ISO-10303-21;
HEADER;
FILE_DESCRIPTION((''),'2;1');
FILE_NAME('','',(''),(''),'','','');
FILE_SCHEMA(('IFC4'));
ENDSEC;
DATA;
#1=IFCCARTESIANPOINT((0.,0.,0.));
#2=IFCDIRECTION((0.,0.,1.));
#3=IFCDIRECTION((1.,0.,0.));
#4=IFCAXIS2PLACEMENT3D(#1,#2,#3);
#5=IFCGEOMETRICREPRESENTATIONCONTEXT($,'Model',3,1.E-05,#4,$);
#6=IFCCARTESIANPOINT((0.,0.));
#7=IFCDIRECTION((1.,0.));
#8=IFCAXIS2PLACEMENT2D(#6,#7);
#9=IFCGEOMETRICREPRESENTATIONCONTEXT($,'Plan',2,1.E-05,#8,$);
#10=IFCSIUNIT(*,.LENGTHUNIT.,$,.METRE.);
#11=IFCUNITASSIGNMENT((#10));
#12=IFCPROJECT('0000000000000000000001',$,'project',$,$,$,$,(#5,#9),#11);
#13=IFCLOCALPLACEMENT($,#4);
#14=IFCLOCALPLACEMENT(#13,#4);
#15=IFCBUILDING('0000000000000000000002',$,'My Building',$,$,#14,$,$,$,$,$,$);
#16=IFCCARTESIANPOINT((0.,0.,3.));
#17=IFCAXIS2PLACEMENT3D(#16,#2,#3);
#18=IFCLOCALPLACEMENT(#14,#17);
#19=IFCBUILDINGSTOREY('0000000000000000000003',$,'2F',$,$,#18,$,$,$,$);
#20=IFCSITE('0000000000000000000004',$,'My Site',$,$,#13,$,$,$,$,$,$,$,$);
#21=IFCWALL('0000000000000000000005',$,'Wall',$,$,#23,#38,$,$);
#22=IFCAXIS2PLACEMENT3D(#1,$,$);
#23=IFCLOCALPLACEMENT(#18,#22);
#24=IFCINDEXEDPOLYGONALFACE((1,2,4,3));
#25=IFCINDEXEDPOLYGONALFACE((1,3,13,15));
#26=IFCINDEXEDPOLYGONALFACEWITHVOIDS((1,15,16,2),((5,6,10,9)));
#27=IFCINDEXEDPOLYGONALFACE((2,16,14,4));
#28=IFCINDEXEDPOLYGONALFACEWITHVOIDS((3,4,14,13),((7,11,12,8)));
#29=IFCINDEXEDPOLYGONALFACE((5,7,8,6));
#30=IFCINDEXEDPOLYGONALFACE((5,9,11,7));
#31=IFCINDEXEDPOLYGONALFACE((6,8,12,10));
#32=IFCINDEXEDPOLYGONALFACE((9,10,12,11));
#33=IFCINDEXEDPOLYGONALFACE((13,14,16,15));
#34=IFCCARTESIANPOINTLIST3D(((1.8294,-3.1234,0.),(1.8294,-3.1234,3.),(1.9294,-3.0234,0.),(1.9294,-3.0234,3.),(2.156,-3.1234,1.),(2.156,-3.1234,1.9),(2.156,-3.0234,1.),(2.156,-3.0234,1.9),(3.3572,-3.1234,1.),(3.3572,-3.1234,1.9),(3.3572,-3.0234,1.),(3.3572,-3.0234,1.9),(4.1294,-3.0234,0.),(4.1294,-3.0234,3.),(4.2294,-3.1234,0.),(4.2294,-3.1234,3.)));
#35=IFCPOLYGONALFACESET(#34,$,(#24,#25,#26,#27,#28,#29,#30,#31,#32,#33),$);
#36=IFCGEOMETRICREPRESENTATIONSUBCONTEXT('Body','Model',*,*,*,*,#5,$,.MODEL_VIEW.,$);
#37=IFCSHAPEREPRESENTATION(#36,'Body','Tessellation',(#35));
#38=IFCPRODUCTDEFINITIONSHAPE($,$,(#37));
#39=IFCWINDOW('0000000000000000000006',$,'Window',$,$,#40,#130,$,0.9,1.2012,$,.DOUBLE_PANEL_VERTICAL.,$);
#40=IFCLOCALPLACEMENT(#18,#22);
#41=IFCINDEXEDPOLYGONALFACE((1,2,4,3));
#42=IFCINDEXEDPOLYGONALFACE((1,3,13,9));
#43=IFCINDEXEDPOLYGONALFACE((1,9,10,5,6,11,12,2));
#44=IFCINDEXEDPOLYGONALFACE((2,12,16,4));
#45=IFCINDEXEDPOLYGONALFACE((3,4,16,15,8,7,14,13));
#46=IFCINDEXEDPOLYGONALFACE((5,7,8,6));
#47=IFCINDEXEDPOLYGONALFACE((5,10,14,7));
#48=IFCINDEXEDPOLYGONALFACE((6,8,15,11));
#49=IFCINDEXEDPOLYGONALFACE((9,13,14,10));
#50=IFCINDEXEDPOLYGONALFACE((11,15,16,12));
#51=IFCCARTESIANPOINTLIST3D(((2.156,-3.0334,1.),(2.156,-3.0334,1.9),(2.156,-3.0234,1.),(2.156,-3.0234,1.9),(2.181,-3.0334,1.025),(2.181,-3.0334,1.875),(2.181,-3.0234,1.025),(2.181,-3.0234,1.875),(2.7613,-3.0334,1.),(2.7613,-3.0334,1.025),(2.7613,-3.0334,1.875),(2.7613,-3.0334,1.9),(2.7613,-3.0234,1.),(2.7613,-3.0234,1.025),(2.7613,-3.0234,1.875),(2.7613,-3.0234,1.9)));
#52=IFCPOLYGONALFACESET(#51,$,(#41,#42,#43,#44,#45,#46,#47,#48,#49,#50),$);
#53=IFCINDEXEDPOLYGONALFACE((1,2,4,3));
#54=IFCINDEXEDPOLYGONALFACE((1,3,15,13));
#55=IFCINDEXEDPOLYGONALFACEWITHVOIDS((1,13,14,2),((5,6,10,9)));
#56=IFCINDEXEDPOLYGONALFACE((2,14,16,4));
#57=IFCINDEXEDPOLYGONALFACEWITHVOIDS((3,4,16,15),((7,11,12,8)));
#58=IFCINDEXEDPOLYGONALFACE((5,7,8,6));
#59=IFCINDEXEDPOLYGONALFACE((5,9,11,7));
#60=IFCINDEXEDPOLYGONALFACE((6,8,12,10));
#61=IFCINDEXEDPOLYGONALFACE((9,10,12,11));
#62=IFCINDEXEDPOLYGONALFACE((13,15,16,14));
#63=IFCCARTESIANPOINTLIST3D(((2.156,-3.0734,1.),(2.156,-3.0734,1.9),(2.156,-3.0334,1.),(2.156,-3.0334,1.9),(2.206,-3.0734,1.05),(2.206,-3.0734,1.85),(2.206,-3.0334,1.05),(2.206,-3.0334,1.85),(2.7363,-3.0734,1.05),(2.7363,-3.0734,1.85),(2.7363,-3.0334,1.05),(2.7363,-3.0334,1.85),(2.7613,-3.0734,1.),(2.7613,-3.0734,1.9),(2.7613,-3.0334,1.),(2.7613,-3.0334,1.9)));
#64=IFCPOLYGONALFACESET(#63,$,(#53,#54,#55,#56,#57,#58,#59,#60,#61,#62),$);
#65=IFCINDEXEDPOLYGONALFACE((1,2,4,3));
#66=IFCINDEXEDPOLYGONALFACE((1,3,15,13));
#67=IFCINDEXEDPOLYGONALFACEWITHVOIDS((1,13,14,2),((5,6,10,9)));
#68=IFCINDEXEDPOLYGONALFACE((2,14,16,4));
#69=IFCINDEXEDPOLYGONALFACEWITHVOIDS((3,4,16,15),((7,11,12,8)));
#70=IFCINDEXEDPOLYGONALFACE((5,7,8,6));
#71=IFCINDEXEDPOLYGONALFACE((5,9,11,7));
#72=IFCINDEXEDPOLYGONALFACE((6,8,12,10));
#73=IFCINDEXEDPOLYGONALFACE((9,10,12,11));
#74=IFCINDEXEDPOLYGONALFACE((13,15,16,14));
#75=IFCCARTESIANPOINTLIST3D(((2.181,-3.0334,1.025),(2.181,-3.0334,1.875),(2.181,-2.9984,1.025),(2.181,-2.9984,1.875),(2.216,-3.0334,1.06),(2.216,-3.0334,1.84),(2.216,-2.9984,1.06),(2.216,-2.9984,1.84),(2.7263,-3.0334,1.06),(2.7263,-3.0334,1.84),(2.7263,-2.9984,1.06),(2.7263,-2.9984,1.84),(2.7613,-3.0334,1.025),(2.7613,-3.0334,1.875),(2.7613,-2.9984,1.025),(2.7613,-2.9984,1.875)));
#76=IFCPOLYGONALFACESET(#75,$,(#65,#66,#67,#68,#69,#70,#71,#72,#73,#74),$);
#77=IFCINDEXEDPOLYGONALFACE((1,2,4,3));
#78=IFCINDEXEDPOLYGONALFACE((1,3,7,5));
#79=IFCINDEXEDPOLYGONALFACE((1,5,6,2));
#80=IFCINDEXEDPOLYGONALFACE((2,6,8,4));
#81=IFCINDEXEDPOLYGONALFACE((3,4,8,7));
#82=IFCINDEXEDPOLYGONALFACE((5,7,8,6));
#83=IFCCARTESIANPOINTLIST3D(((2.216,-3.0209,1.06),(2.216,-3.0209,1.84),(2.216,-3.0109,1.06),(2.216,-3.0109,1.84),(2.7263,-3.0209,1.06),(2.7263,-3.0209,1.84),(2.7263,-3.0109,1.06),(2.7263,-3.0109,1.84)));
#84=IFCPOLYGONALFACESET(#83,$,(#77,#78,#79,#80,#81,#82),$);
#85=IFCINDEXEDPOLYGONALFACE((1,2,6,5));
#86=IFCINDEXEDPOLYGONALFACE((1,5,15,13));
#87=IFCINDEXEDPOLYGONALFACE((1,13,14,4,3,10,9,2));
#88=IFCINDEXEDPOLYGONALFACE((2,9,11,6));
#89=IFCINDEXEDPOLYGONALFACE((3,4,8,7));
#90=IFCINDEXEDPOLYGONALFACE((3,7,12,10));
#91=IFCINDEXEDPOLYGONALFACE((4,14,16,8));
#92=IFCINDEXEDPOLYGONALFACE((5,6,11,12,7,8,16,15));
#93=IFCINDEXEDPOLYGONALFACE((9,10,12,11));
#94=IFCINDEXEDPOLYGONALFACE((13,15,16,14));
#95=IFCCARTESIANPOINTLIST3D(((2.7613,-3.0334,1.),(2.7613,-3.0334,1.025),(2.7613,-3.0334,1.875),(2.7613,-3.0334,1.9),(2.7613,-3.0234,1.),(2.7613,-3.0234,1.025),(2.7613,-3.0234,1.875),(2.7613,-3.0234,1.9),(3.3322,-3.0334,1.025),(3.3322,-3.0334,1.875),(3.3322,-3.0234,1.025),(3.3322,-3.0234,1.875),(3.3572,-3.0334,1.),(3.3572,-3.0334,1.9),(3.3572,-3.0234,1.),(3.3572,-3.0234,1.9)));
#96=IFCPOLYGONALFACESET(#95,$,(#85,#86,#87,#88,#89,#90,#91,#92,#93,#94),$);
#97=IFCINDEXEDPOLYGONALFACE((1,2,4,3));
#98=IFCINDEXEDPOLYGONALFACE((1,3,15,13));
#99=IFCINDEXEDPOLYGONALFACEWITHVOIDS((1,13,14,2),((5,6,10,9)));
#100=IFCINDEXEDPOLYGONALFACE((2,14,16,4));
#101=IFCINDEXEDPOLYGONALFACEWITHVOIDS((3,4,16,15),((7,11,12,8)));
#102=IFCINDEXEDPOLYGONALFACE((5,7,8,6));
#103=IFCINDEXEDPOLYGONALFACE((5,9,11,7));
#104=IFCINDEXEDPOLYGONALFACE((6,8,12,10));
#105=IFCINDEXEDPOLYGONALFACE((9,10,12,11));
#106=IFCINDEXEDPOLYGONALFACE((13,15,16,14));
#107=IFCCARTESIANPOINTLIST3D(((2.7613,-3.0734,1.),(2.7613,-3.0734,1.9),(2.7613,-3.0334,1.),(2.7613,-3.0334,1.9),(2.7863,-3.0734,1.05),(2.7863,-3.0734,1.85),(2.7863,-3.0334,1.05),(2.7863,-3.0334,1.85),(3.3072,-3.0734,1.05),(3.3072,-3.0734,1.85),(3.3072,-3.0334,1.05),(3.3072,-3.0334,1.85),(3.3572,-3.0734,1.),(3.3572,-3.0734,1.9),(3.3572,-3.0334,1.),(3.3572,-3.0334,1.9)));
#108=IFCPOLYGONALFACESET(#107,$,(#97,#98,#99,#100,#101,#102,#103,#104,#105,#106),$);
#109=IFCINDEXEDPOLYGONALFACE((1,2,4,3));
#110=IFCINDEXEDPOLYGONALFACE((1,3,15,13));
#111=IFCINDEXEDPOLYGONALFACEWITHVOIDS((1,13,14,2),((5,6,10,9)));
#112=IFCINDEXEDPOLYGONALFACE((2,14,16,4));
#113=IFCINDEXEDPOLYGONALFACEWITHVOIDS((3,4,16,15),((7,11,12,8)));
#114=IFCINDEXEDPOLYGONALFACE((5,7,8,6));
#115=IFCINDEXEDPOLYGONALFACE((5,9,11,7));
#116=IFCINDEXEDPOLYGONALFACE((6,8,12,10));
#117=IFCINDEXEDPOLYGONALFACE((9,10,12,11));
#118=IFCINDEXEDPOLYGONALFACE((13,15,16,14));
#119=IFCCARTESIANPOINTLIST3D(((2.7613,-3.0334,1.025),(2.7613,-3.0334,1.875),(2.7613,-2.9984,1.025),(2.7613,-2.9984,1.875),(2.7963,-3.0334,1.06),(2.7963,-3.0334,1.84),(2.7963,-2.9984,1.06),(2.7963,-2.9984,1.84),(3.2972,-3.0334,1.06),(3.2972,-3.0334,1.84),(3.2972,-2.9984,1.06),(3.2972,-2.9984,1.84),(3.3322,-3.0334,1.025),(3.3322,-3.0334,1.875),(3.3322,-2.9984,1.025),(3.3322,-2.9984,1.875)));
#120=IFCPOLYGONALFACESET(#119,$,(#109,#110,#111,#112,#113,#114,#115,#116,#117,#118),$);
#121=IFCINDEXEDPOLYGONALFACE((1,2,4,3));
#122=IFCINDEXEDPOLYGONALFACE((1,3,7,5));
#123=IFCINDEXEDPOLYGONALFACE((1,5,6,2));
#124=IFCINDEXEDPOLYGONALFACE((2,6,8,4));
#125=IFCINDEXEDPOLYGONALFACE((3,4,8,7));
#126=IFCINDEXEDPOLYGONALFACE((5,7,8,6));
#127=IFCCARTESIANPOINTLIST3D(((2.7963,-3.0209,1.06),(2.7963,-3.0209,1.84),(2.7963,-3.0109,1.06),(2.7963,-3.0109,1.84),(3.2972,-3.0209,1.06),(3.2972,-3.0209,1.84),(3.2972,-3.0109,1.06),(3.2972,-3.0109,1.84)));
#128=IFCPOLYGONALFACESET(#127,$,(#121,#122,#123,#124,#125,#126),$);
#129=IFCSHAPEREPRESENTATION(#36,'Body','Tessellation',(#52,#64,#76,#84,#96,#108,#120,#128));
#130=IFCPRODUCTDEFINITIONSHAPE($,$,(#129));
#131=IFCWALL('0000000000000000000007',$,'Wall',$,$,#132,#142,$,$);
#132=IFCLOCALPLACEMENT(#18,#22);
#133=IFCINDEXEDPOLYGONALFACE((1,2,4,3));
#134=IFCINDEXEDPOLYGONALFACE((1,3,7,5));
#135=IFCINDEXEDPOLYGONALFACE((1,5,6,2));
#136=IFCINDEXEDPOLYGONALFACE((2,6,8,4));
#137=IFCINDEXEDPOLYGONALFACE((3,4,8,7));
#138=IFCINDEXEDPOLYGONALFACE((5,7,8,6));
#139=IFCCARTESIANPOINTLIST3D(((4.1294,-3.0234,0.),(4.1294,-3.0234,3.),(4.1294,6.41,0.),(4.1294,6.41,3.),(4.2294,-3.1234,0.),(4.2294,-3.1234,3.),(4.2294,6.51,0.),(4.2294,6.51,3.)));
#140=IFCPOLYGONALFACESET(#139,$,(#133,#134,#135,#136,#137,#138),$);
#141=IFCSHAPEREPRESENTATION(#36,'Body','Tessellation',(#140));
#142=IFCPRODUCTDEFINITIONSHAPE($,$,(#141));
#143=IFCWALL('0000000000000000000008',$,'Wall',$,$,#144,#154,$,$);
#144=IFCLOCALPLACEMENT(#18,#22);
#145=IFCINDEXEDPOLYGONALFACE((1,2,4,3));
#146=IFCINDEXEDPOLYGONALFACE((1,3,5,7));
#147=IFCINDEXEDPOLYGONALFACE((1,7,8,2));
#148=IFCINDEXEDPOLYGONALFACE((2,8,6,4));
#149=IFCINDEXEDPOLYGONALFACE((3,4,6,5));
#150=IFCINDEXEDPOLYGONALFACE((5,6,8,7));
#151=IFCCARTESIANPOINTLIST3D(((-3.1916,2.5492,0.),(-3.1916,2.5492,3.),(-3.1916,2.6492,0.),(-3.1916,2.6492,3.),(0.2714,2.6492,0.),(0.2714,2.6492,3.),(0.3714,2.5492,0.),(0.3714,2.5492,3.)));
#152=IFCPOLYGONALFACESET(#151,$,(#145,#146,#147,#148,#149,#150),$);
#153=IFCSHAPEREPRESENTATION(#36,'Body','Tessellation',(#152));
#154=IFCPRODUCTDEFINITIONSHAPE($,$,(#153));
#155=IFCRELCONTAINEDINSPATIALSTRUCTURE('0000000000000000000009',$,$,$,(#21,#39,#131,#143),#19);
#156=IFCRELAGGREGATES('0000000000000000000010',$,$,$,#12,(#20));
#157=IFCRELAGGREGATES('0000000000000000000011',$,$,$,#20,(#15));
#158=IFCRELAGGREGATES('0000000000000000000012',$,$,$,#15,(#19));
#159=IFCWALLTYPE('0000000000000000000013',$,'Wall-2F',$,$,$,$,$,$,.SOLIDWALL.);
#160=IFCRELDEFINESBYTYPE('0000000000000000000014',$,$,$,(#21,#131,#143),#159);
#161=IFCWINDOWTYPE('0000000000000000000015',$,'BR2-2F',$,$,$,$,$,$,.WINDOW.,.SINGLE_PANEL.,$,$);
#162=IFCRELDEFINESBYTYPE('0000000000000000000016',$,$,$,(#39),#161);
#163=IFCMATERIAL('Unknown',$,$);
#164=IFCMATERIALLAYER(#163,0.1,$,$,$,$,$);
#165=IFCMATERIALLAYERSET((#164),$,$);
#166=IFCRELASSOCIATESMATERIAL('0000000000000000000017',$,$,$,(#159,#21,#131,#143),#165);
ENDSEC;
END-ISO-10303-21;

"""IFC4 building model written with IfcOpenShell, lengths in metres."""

from ifc_helpers import new_model, entity, si_unit, frame, origin_with_axes, origin_2d_with_axis, place, context, subcontext, project, spatial, line, indexed_curve, outline, extrude, shape, source, transform, mapped, material, layer, layer_set, layer_usage, type_object, type_shapes, element, fill, save


model = new_model("IFC4")

# Units and contexts
model_context = context("Model", 3, precision=1e-05, world=origin_with_axes())
plan_context = context("Plan", 2, precision=1e-05, world=origin_2d_with_axis())
body_context_1 = subcontext(model_context, "Body", "Model", "MODEL_VIEW")
body_context_2 = subcontext(plan_context, "Body", "Plan", "PLAN_VIEW")
ifc_project = project(units=[si_unit("LENGTHUNIT", "METRE")], contexts=[model_context, plan_context])

# Site, building, storey
site_placement = place(None, origin_with_axes())
site = spatial("IfcSite", under=ifc_project, at=site_placement, Name="My Site")
building_placement = place(site_placement, origin_with_axes())
building = spatial("IfcBuilding", under=site, at=building_placement, Name="My Building")
storey_placement = place(building_placement, frame((0.0, 0.0, 3.0), z_axis=(0.0, 0.0, 1.0), x_axis=(1.0, 0.0, 0.0)))
storey = spatial("IfcBuildingStorey", under=building, at=storey_placement, Name="2F")

# Shared definitions
ifc_material = material(Name="Unknown")

# Shared definitions
ifc_layer_1 = layer(ifc_material, 0.1)
ifc_layer_set_1 = layer_set([ifc_layer_1])
wall_type_1 = type_object("IfcWallType", Name="Wall-2F", PredefinedType="SOLIDWALL", material=ifc_layer_set_1)

# Wall, opening, window
ifc_layer_usage_1 = layer_usage(ifc_layer_set_1, "AXIS2", "POSITIVE", 0.0)
wall_1_placement = place(storey_placement, frame((1.8294, -3.1234, 0.0), z_axis=(0.0, 0.0, 1.0), x_axis=(1.0, 0.0, 0.0)))
wall_1 = element("IfcWall", 1, at=wall_1_placement, inside=storey, type_object=wall_type_1, material=ifc_layer_usage_1, Name="Wall", context=body_context_1, shape_type="SweptSolid", body=[
    extrude(outline(indexed_curve([(0.0, 0.0), (0.1, 0.1), (2.3, 0.1), (2.4, 0.0)], segments=[line(1, 2, 3, 4, 1)])), origin_with_axes(), (0.0, 0.0, 1.0), 3.0),
])
shared_shape_1 = source(origin_with_axes(), body_context_1, "Body", "SweptSolid", [
    extrude(outline(indexed_curve([(0.0, 0.0), (1.2012, 0.0), (1.2012, 0.9), (0.0, 0.9)], segments=[line(1, 2, 3, 4, 1)])), frame((0.0, -0.6, 0.0), z_axis=(0.0, -1.0, 0.0), x_axis=(1.0, 0.0, 0.0)), (0.0, 0.0, -1.0), 1.2),
])
opening_1_placement = place(wall_1_placement, frame((0.3266, 0.0, 1.0), z_axis=(0.0, 0.0, 1.0), x_axis=(1.0, 0.0, 0.0)))
opening_1 = element("IfcOpeningElement", 2, at=opening_1_placement, cuts=wall_1, PredefinedType="OPENING", context=body_context_1, shape_type="MappedRepresentation", body=[
    mapped(shared_shape_1, transform((0.0, 0.0, 0.0), x_axis=(1.0, 0.0, 0.0), y_axis=(0.0, 1.0, 0.0), z_axis=(0.0, 0.0, 1.0), scale=1.0)),
])
window_type = type_object("IfcWindowType", Name="BR2-2F", PartitioningType="SINGLE_PANEL", PredefinedType="WINDOW")
shared_shape_2 = source(origin_with_axes(), body_context_1, "Body", "SweptSolid", [
    extrude(outline(indexed_curve([(0.6053, 0.0), (0.0, 0.0), (0.0, 0.9), (0.6053, 0.9), (0.6053, 0.875), (0.025, 0.875), (0.025, 0.025), (0.6053, 0.025)], segments=[line(1, 2, 3, 4, 5, 6, 7, 8, 1)])), frame((0.0, 0.09, 0.0), z_axis=(0.0, -1.0, 0.0), x_axis=(1.0, 0.0, 0.0)), (0.0, 0.0, -1.0), 0.01),
    extrude(outline(indexed_curve([(0.0, 0.0), (0.6053, 0.0), (0.6053, 0.9), (0.0, 0.9)], segments=[line(1, 2, 3, 4, 1)]), holes=[indexed_curve([(0.05, 0.05), (0.5803, 0.05), (0.5803, 0.85), (0.05, 0.85)], segments=[line(1, 2, 3, 4, 1)])]), frame((0.0, 0.05, 0.0), z_axis=(0.0, -1.0, 0.0), x_axis=(1.0, 0.0, 0.0)), (0.0, 0.0, -1.0), 0.04),
    extrude(outline(indexed_curve([(0.0, 0.0), (0.5803, 0.0), (0.5803, 0.85), (0.0, 0.85)], segments=[line(1, 2, 3, 4, 1)]), holes=[indexed_curve([(0.035, 0.035), (0.5453, 0.035), (0.5453, 0.815), (0.035, 0.815)], segments=[line(1, 2, 3, 4, 1)])]), frame((0.025, 0.09, 0.025), z_axis=(0.0, -1.0, 0.0), x_axis=(1.0, 0.0, 0.0)), (0.0, 0.0, -1.0), 0.035),
    extrude(outline(indexed_curve([(0.035, 0.035), (0.5453, 0.035), (0.5453, 0.815), (0.035, 0.815)], segments=[line(1, 2, 3, 4, 1)])), frame((0.025, 0.1025, 0.025), z_axis=(0.0, -1.0, 0.0), x_axis=(1.0, 0.0, 0.0)), (0.0, 0.0, -1.0), 0.01),
    extrude(outline(indexed_curve([(0.0, 0.9), (0.5958, 0.9), (0.5958, 0.0), (0.0, 0.0), (0.0, 0.025), (0.5708, 0.025), (0.5708, 0.875), (0.0, 0.875)], segments=[line(1, 2, 3, 4, 5, 6, 7, 8, 1)])), frame((0.6053, 0.09, 0.0), z_axis=(0.0, -1.0, 0.0), x_axis=(1.0, 0.0, 0.0)), (0.0, 0.0, -1.0), 0.01),
    extrude(outline(indexed_curve([(0.0, 0.0), (0.5958, 0.0), (0.5958, 0.9), (0.0, 0.9)], segments=[line(1, 2, 3, 4, 1)]), holes=[indexed_curve([(0.025, 0.05), (0.5458, 0.05), (0.5458, 0.85), (0.025, 0.85)], segments=[line(1, 2, 3, 4, 1)])]), frame((0.6053, 0.05, 0.0), z_axis=(0.0, -1.0, 0.0), x_axis=(1.0, 0.0, 0.0)), (0.0, 0.0, -1.0), 0.04),
    extrude(outline(indexed_curve([(0.0, 0.0), (0.5708, 0.0), (0.5708, 0.85), (0.0, 0.85)], segments=[line(1, 2, 3, 4, 1)]), holes=[indexed_curve([(0.035, 0.035), (0.5358, 0.035), (0.5358, 0.815), (0.035, 0.815)], segments=[line(1, 2, 3, 4, 1)])]), frame((0.6053, 0.09, 0.025), z_axis=(0.0, -1.0, 0.0), x_axis=(1.0, 0.0, 0.0)), (0.0, 0.0, -1.0), 0.035),
    extrude(outline(indexed_curve([(0.035, 0.035), (0.5358, 0.035), (0.5358, 0.815), (0.035, 0.815)], segments=[line(1, 2, 3, 4, 1)])), frame((0.6053, 0.1025, 0.025), z_axis=(0.0, -1.0, 0.0), x_axis=(1.0, 0.0, 0.0)), (0.0, 0.0, -1.0), 0.01),
])
shared_shape_3 = source(origin_with_axes(), body_context_2, "Body", "Curve2D", [
    entity("IfcIndexedPolyCurve", entity("IfcCartesianPointList2D", [[0.05, 0.05], [0.5803, 0.05]])),
    entity("IfcIndexedPolyCurve", entity("IfcCartesianPointList2D", [[0.0, 0.1], [0.025, 0.1], [0.025, 0.09], [0.05, 0.09], [0.05, 0.05], [0.0, 0.05]]), [entity("IfcLineIndex", [1, 2, 3, 4, 5, 6, 1])]),
    entity("IfcIndexedPolyCurve", entity("IfcCartesianPointList2D", [[0.6053, 0.1], [0.6053, 0.1], [0.6053, 0.09], [0.5803, 0.09], [0.5803, 0.05], [0.6053, 0.05]])),
    entity("IfcIndexedPolyCurve", entity("IfcCartesianPointList2D", [[0.025, 0.09], [0.06, 0.09], [0.06, 0.125], [0.025, 0.125]]), [entity("IfcLineIndex", [1, 2, 3, 4, 1])]),
    entity("IfcIndexedPolyCurve", entity("IfcCartesianPointList2D", [[0.6053, 0.09], [0.5703, 0.09], [0.5703, 0.125], [0.6053, 0.125]]), [entity("IfcLineIndex", [1, 2, 3, 4, 1])]),
    entity("IfcIndexedPolyCurve", entity("IfcCartesianPointList2D", [[0.06, 0.09], [0.5703, 0.09]])),
    entity("IfcIndexedPolyCurve", entity("IfcCartesianPointList2D", [[0.06, 0.125], [0.5703, 0.125]])),
    entity("IfcIndexedPolyCurve", entity("IfcCartesianPointList2D", [[0.06, 0.1075], [0.5703, 0.1075]])),
    entity("IfcIndexedPolyCurve", entity("IfcCartesianPointList2D", [[0.6303, 0.05], [1.1512, 0.05]])),
    entity("IfcIndexedPolyCurve", entity("IfcCartesianPointList2D", [[0.6053, 0.1], [0.6053, 0.1], [0.6053, 0.09], [0.6303, 0.09], [0.6303, 0.05], [0.6053, 0.05]])),
    entity("IfcIndexedPolyCurve", entity("IfcCartesianPointList2D", [[1.2012, 0.1], [1.1762, 0.1], [1.1762, 0.09], [1.1512, 0.09], [1.1512, 0.05], [1.2012, 0.05]]), [entity("IfcLineIndex", [1, 2, 3, 4, 5, 6, 1])]),
    entity("IfcIndexedPolyCurve", entity("IfcCartesianPointList2D", [[0.6053, 0.09], [0.6403, 0.09], [0.6403, 0.125], [0.6053, 0.125]]), [entity("IfcLineIndex", [1, 2, 3, 4, 1])]),
    entity("IfcIndexedPolyCurve", entity("IfcCartesianPointList2D", [[1.1762, 0.09], [1.1412, 0.09], [1.1412, 0.125], [1.1762, 0.125]]), [entity("IfcLineIndex", [1, 2, 3, 4, 1])]),
    entity("IfcIndexedPolyCurve", entity("IfcCartesianPointList2D", [[0.6403, 0.09], [1.1412, 0.09]])),
    entity("IfcIndexedPolyCurve", entity("IfcCartesianPointList2D", [[0.6403, 0.125], [1.1412, 0.125]])),
    entity("IfcIndexedPolyCurve", entity("IfcCartesianPointList2D", [[0.6403, 0.1075], [1.1412, 0.1075]])),
])
type_shapes(window_type, [shared_shape_2, shared_shape_3])
window_placement = place(opening_1_placement, origin_with_axes())
window = element("IfcWindow", 3, at=window_placement, inside=storey, type_object=window_type, Name="Window", OverallHeight=0.9, OverallWidth=1.2012, PartitioningType="DOUBLE_PANEL_VERTICAL", shapes=[
    shape(body_context_1, "Body", "MappedRepresentation", [mapped(shared_shape_2, transform((0.0, 0.0, 0.0), x_axis=(1.0, 0.0, 0.0), y_axis=(0.0, 1.0, 0.0), z_axis=(0.0, 0.0, 1.0), scale=1.0))]),
    shape(body_context_2, "Body", "MappedRepresentation", [mapped(shared_shape_3, transform((0.0, 0.0, 0.0), x_axis=(1.0, 0.0, 0.0), y_axis=(0.0, 1.0, 0.0), z_axis=(0.0, 0.0, 1.0), scale=1.0))]),
])
fill(opening_1, window)

# Walls
ifc_layer_usage_2 = layer_usage(ifc_layer_set_1, "AXIS2", "POSITIVE", 0.0)
wall_2_placement = place(storey_placement, frame((4.2294, -3.1234, 0.0), z_axis=(0.0, 0.0, 1.0), x_axis=(0.0, 1.0, 0.0)))
element("IfcWall", 4, at=wall_2_placement, inside=storey, type_object=wall_type_1, material=ifc_layer_usage_2, Name="Wall", context=body_context_1, shape_type="SweptSolid", body=[
    extrude(outline(indexed_curve([(0.0, 0.0), (0.1, 0.1), (9.5334, 0.1), (9.6334, 0.0)], segments=[line(1, 2, 3, 4, 1)])), origin_with_axes(), (0.0, 0.0, 1.0), 3.0),
])
ifc_layer_usage_3 = layer_usage(ifc_layer_set_1, "AXIS2", "POSITIVE", 0.0)
wall_3_placement = place(storey_placement, frame((-3.1916, 2.5492, 0.0), z_axis=(0.0, 0.0, 1.0), x_axis=(1.0, 0.0, 0.0)))
element("IfcWall", 5, at=wall_3_placement, inside=storey, type_object=wall_type_1, material=ifc_layer_usage_3, Name="Wall", context=body_context_1, shape_type="SweptSolid", body=[
    extrude(outline(indexed_curve([(0.0, 0.0), (0.0, 0.1), (3.463, 0.1), (3.563, 0.0)], segments=[line(1, 2, 3, 4, 1)])), origin_with_axes(), (0.0, 0.0, 1.0), 3.0),
])

save(model, "model.ifc")
